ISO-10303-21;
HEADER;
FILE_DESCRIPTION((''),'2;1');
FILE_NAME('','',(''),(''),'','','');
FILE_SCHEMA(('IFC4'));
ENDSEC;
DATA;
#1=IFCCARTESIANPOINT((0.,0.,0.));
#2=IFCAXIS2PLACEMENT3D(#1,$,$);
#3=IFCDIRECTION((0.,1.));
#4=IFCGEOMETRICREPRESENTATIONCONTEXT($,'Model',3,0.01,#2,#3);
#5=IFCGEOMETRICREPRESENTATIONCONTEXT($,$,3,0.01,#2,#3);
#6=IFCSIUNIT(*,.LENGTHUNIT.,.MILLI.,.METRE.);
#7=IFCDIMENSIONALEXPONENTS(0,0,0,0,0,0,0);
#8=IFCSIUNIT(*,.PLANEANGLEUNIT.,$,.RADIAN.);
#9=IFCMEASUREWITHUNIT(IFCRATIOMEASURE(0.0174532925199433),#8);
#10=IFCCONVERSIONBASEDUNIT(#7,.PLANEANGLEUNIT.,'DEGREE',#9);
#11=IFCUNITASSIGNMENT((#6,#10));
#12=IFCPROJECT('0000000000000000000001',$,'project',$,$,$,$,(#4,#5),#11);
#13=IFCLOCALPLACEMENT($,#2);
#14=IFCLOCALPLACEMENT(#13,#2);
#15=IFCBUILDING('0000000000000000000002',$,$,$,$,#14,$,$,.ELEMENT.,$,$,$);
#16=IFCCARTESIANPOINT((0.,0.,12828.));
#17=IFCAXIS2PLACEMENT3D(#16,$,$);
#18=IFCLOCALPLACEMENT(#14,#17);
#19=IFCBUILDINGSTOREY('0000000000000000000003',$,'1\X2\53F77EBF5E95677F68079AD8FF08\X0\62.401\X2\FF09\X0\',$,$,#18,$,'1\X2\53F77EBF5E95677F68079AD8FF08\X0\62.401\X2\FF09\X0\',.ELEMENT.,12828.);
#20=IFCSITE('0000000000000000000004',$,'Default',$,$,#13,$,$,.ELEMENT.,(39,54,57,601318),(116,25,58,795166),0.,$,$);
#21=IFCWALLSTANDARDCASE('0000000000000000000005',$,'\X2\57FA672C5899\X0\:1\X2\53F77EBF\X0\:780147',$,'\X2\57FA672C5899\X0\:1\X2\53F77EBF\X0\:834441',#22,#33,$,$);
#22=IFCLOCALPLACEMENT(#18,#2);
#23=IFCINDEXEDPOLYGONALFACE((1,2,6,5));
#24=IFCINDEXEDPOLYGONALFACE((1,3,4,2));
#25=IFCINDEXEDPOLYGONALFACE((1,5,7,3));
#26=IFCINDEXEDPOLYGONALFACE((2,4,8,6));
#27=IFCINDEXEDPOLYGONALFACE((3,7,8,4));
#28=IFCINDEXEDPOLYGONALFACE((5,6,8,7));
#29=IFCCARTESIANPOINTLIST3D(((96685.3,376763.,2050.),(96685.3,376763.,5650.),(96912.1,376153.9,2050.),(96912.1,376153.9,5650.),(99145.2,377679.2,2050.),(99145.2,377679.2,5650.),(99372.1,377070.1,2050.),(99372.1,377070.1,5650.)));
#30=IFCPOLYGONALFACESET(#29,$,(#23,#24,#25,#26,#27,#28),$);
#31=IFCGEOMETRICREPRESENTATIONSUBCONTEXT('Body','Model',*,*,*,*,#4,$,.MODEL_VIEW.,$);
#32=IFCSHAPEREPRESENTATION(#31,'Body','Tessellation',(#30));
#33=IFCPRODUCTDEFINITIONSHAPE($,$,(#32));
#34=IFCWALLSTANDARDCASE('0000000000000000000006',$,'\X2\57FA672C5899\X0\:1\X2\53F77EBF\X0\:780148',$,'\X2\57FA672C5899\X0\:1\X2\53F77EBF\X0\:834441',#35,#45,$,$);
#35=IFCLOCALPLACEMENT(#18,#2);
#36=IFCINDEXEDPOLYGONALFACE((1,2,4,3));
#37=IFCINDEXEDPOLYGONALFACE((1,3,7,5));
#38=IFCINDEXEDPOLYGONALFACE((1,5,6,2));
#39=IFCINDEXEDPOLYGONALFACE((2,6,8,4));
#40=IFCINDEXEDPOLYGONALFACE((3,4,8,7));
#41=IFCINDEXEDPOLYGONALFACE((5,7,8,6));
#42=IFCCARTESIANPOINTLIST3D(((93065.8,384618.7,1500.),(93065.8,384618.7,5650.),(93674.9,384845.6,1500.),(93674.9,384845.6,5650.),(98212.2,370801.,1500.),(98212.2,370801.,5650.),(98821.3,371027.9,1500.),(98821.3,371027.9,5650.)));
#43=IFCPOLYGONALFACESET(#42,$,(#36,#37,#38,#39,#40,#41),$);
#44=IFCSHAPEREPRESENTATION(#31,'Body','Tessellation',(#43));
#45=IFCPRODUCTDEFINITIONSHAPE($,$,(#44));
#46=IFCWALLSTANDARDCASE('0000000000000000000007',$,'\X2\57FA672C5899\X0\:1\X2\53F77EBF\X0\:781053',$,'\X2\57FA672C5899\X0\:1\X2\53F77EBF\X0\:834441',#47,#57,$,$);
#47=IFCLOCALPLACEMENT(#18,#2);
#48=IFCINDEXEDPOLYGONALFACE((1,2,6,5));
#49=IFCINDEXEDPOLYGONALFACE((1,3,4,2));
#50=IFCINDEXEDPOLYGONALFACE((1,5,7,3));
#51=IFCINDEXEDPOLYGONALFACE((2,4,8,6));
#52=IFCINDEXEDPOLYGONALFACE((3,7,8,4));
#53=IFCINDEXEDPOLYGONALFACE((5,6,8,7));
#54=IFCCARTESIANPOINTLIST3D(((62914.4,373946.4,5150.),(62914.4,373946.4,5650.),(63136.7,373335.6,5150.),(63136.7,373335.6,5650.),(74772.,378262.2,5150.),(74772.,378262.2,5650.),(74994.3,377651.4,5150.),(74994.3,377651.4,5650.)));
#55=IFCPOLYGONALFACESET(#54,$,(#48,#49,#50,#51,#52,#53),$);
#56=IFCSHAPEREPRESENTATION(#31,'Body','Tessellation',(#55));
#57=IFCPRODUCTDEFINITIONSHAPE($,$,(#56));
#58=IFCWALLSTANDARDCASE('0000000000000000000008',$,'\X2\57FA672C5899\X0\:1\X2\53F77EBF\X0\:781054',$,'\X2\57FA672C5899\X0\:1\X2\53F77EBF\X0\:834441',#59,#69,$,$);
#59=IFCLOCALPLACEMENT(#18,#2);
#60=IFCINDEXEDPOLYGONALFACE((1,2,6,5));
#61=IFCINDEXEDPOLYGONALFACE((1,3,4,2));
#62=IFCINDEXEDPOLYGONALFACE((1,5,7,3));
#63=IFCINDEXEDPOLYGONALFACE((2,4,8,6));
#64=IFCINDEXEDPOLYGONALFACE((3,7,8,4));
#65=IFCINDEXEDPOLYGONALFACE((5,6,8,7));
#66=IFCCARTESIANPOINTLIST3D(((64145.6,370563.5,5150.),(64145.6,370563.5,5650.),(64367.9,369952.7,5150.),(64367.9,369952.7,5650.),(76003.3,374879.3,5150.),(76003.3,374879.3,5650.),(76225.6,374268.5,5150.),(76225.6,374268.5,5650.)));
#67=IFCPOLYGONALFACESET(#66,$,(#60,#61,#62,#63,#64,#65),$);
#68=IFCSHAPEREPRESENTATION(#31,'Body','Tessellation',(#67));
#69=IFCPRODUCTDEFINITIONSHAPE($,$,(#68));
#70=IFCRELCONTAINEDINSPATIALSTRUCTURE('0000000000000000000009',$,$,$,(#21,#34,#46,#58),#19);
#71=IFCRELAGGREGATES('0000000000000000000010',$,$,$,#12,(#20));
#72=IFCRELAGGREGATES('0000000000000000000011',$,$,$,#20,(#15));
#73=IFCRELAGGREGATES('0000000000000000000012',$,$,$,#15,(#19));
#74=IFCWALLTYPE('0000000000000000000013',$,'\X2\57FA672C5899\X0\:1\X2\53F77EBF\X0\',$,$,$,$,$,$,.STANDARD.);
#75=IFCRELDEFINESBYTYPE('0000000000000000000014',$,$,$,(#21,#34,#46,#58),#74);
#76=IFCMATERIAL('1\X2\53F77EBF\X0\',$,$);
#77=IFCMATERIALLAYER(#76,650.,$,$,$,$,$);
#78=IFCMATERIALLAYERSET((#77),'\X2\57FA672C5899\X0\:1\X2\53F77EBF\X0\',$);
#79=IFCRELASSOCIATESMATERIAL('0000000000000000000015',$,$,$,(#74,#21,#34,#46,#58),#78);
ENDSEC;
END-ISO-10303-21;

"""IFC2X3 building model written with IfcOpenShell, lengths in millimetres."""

from ifc_helpers import new_model, entity, si_unit, converted_unit, direction, frame, frame_2d, origin, place, context, subcontext, project, spatial, rectangle, extrude, material, layer, layer_set, layer_usage, type_object, element, save


model = new_model("IFC2X3")

# Units and contexts
model_context = context("Model", 3, precision=0.01, world=origin(), true_north=direction((0.0, 1.0)))
context_of_model = context(None, 3, precision=0.01, world=origin(), true_north=direction((0.0, 1.0)))
body_context = subcontext(model_context, "Body", "Model", "MODEL_VIEW")
ifc_project = project(units=[si_unit("LENGTHUNIT", "METRE", prefix="MILLI"), converted_unit("PLANEANGLEUNIT", "DEGREE", entity("IfcRatioMeasure", 0.0174532925199433), si_unit("PLANEANGLEUNIT", "RADIAN"), dimensions=[0, 0, 0, 0, 0, 0, 0])], contexts=[model_context, context_of_model])

# Site, building, storey
site_placement = place(None, origin())
site = spatial("IfcSite", under=ifc_project, at=site_placement, Name="Default", CompositionType="ELEMENT", RefLatitude=(39, 54, 57, 601318), RefLongitude=(116, 25, 58, 795166), RefElevation=0.0)
building_placement = place(site_placement, origin())
building = spatial("IfcBuilding", under=site, at=building_placement, CompositionType="ELEMENT")
storey_placement = place(building_placement, frame((0.0, 0.0, 12828.0)))
storey = spatial("IfcBuildingStorey", under=building, at=storey_placement, Name="1号线底板标高（62.401）", LongName="1号线底板标高（62.401）", CompositionType="ELEMENT", Elevation=12828.0)

# Walls
ifc_material_1 = material(Name="1号线")
ifc_layer = layer(ifc_material_1, 650.0)
ifc_layer_set = layer_set([ifc_layer], Name="基本墙:1号线")
wall_type = type_object("IfcWallType", Name="基本墙:1号线", PredefinedType="STANDARD", material=ifc_layer_set)
ifc_layer_usage_1 = layer_usage(ifc_layer_set, "AXIS2", "NEGATIVE", 325.0)
wall_1_placement = place(storey_placement, frame((99258.6, 377374.6, 2050.0), z_axis=(0.0, 0.0, 1.0), x_axis=(-0.937112, -0.349028, 0.0)))
element("IfcWallStandardCase", 1, at=wall_1_placement, inside=storey, type_object=wall_type, material=ifc_layer_usage_1, Name="基本墙:1号线:780147", ObjectType="基本墙:1号线:834441", context=body_context, shape_type="SweptSolid", body=[
    extrude(rectangle(XDim=2625.0, YDim=650.0, at=frame_2d((1312.5, 0.0), x_axis=(-1.0, 0.0))), origin(), (0.0, 0.0, 1.0), 3600.0),
])
ifc_layer_usage_2 = layer_usage(ifc_layer_set, "AXIS2", "NEGATIVE", 325.0)
wall_2_placement = place(storey_placement, frame((98516.8, 370914.4, 1500.0), z_axis=(0.0, 0.0, 1.0), x_axis=(-0.349028, 0.937112, 0.0)))
element("IfcWallStandardCase", 2, at=wall_2_placement, inside=storey, type_object=wall_type, material=ifc_layer_usage_2, Name="基本墙:1号线:780148", ObjectType="基本墙:1号线:834441", context=body_context, shape_type="SweptSolid", body=[
    extrude(rectangle(XDim=14745.0, YDim=650.0, at=frame_2d((7372.5, 0.0), x_axis=(-1.0, 0.0))), origin(), (0.0, 0.0, 1.0), 4150.0),
])
ifc_layer_usage_3 = layer_usage(ifc_layer_set, "AXIS2", "NEGATIVE", 325.0)
wall_3_placement = place(storey_placement, frame((63025.5, 373641.0, 5150.0), z_axis=(0.0, 0.0, 1.0), x_axis=(0.939693, 0.34202, 0.0)))
element("IfcWallStandardCase", 3, at=wall_3_placement, inside=storey, type_object=wall_type, material=ifc_layer_usage_3, Name="基本墙:1号线:781053", ObjectType="基本墙:1号线:834441", context=body_context, shape_type="SweptSolid", body=[
    extrude(rectangle(XDim=12618.6, YDim=650.0, at=frame_2d((6309.3, 0.0), x_axis=(-1.0, 0.0))), origin(), (0.0, 0.0, 1.0), 500.0),
])
ifc_layer_usage_4 = layer_usage(ifc_layer_set, "AXIS2", "NEGATIVE", 325.0)
wall_4_placement = place(storey_placement, frame((64256.8, 370258.1, 5150.0), z_axis=(0.0, 0.0, 1.0), x_axis=(0.939693, 0.34202, 0.0)))
element("IfcWallStandardCase", 4, at=wall_4_placement, inside=storey, type_object=wall_type, material=ifc_layer_usage_4, Name="基本墙:1号线:781054", ObjectType="基本墙:1号线:834441", context=body_context, shape_type="SweptSolid", body=[
    extrude(rectangle(XDim=12618.6, YDim=650.0, at=frame_2d((6309.3, 0.0), x_axis=(-1.0, 0.0))), origin(), (0.0, 0.0, 1.0), 500.0),
])

save(model, "model.ifc")
